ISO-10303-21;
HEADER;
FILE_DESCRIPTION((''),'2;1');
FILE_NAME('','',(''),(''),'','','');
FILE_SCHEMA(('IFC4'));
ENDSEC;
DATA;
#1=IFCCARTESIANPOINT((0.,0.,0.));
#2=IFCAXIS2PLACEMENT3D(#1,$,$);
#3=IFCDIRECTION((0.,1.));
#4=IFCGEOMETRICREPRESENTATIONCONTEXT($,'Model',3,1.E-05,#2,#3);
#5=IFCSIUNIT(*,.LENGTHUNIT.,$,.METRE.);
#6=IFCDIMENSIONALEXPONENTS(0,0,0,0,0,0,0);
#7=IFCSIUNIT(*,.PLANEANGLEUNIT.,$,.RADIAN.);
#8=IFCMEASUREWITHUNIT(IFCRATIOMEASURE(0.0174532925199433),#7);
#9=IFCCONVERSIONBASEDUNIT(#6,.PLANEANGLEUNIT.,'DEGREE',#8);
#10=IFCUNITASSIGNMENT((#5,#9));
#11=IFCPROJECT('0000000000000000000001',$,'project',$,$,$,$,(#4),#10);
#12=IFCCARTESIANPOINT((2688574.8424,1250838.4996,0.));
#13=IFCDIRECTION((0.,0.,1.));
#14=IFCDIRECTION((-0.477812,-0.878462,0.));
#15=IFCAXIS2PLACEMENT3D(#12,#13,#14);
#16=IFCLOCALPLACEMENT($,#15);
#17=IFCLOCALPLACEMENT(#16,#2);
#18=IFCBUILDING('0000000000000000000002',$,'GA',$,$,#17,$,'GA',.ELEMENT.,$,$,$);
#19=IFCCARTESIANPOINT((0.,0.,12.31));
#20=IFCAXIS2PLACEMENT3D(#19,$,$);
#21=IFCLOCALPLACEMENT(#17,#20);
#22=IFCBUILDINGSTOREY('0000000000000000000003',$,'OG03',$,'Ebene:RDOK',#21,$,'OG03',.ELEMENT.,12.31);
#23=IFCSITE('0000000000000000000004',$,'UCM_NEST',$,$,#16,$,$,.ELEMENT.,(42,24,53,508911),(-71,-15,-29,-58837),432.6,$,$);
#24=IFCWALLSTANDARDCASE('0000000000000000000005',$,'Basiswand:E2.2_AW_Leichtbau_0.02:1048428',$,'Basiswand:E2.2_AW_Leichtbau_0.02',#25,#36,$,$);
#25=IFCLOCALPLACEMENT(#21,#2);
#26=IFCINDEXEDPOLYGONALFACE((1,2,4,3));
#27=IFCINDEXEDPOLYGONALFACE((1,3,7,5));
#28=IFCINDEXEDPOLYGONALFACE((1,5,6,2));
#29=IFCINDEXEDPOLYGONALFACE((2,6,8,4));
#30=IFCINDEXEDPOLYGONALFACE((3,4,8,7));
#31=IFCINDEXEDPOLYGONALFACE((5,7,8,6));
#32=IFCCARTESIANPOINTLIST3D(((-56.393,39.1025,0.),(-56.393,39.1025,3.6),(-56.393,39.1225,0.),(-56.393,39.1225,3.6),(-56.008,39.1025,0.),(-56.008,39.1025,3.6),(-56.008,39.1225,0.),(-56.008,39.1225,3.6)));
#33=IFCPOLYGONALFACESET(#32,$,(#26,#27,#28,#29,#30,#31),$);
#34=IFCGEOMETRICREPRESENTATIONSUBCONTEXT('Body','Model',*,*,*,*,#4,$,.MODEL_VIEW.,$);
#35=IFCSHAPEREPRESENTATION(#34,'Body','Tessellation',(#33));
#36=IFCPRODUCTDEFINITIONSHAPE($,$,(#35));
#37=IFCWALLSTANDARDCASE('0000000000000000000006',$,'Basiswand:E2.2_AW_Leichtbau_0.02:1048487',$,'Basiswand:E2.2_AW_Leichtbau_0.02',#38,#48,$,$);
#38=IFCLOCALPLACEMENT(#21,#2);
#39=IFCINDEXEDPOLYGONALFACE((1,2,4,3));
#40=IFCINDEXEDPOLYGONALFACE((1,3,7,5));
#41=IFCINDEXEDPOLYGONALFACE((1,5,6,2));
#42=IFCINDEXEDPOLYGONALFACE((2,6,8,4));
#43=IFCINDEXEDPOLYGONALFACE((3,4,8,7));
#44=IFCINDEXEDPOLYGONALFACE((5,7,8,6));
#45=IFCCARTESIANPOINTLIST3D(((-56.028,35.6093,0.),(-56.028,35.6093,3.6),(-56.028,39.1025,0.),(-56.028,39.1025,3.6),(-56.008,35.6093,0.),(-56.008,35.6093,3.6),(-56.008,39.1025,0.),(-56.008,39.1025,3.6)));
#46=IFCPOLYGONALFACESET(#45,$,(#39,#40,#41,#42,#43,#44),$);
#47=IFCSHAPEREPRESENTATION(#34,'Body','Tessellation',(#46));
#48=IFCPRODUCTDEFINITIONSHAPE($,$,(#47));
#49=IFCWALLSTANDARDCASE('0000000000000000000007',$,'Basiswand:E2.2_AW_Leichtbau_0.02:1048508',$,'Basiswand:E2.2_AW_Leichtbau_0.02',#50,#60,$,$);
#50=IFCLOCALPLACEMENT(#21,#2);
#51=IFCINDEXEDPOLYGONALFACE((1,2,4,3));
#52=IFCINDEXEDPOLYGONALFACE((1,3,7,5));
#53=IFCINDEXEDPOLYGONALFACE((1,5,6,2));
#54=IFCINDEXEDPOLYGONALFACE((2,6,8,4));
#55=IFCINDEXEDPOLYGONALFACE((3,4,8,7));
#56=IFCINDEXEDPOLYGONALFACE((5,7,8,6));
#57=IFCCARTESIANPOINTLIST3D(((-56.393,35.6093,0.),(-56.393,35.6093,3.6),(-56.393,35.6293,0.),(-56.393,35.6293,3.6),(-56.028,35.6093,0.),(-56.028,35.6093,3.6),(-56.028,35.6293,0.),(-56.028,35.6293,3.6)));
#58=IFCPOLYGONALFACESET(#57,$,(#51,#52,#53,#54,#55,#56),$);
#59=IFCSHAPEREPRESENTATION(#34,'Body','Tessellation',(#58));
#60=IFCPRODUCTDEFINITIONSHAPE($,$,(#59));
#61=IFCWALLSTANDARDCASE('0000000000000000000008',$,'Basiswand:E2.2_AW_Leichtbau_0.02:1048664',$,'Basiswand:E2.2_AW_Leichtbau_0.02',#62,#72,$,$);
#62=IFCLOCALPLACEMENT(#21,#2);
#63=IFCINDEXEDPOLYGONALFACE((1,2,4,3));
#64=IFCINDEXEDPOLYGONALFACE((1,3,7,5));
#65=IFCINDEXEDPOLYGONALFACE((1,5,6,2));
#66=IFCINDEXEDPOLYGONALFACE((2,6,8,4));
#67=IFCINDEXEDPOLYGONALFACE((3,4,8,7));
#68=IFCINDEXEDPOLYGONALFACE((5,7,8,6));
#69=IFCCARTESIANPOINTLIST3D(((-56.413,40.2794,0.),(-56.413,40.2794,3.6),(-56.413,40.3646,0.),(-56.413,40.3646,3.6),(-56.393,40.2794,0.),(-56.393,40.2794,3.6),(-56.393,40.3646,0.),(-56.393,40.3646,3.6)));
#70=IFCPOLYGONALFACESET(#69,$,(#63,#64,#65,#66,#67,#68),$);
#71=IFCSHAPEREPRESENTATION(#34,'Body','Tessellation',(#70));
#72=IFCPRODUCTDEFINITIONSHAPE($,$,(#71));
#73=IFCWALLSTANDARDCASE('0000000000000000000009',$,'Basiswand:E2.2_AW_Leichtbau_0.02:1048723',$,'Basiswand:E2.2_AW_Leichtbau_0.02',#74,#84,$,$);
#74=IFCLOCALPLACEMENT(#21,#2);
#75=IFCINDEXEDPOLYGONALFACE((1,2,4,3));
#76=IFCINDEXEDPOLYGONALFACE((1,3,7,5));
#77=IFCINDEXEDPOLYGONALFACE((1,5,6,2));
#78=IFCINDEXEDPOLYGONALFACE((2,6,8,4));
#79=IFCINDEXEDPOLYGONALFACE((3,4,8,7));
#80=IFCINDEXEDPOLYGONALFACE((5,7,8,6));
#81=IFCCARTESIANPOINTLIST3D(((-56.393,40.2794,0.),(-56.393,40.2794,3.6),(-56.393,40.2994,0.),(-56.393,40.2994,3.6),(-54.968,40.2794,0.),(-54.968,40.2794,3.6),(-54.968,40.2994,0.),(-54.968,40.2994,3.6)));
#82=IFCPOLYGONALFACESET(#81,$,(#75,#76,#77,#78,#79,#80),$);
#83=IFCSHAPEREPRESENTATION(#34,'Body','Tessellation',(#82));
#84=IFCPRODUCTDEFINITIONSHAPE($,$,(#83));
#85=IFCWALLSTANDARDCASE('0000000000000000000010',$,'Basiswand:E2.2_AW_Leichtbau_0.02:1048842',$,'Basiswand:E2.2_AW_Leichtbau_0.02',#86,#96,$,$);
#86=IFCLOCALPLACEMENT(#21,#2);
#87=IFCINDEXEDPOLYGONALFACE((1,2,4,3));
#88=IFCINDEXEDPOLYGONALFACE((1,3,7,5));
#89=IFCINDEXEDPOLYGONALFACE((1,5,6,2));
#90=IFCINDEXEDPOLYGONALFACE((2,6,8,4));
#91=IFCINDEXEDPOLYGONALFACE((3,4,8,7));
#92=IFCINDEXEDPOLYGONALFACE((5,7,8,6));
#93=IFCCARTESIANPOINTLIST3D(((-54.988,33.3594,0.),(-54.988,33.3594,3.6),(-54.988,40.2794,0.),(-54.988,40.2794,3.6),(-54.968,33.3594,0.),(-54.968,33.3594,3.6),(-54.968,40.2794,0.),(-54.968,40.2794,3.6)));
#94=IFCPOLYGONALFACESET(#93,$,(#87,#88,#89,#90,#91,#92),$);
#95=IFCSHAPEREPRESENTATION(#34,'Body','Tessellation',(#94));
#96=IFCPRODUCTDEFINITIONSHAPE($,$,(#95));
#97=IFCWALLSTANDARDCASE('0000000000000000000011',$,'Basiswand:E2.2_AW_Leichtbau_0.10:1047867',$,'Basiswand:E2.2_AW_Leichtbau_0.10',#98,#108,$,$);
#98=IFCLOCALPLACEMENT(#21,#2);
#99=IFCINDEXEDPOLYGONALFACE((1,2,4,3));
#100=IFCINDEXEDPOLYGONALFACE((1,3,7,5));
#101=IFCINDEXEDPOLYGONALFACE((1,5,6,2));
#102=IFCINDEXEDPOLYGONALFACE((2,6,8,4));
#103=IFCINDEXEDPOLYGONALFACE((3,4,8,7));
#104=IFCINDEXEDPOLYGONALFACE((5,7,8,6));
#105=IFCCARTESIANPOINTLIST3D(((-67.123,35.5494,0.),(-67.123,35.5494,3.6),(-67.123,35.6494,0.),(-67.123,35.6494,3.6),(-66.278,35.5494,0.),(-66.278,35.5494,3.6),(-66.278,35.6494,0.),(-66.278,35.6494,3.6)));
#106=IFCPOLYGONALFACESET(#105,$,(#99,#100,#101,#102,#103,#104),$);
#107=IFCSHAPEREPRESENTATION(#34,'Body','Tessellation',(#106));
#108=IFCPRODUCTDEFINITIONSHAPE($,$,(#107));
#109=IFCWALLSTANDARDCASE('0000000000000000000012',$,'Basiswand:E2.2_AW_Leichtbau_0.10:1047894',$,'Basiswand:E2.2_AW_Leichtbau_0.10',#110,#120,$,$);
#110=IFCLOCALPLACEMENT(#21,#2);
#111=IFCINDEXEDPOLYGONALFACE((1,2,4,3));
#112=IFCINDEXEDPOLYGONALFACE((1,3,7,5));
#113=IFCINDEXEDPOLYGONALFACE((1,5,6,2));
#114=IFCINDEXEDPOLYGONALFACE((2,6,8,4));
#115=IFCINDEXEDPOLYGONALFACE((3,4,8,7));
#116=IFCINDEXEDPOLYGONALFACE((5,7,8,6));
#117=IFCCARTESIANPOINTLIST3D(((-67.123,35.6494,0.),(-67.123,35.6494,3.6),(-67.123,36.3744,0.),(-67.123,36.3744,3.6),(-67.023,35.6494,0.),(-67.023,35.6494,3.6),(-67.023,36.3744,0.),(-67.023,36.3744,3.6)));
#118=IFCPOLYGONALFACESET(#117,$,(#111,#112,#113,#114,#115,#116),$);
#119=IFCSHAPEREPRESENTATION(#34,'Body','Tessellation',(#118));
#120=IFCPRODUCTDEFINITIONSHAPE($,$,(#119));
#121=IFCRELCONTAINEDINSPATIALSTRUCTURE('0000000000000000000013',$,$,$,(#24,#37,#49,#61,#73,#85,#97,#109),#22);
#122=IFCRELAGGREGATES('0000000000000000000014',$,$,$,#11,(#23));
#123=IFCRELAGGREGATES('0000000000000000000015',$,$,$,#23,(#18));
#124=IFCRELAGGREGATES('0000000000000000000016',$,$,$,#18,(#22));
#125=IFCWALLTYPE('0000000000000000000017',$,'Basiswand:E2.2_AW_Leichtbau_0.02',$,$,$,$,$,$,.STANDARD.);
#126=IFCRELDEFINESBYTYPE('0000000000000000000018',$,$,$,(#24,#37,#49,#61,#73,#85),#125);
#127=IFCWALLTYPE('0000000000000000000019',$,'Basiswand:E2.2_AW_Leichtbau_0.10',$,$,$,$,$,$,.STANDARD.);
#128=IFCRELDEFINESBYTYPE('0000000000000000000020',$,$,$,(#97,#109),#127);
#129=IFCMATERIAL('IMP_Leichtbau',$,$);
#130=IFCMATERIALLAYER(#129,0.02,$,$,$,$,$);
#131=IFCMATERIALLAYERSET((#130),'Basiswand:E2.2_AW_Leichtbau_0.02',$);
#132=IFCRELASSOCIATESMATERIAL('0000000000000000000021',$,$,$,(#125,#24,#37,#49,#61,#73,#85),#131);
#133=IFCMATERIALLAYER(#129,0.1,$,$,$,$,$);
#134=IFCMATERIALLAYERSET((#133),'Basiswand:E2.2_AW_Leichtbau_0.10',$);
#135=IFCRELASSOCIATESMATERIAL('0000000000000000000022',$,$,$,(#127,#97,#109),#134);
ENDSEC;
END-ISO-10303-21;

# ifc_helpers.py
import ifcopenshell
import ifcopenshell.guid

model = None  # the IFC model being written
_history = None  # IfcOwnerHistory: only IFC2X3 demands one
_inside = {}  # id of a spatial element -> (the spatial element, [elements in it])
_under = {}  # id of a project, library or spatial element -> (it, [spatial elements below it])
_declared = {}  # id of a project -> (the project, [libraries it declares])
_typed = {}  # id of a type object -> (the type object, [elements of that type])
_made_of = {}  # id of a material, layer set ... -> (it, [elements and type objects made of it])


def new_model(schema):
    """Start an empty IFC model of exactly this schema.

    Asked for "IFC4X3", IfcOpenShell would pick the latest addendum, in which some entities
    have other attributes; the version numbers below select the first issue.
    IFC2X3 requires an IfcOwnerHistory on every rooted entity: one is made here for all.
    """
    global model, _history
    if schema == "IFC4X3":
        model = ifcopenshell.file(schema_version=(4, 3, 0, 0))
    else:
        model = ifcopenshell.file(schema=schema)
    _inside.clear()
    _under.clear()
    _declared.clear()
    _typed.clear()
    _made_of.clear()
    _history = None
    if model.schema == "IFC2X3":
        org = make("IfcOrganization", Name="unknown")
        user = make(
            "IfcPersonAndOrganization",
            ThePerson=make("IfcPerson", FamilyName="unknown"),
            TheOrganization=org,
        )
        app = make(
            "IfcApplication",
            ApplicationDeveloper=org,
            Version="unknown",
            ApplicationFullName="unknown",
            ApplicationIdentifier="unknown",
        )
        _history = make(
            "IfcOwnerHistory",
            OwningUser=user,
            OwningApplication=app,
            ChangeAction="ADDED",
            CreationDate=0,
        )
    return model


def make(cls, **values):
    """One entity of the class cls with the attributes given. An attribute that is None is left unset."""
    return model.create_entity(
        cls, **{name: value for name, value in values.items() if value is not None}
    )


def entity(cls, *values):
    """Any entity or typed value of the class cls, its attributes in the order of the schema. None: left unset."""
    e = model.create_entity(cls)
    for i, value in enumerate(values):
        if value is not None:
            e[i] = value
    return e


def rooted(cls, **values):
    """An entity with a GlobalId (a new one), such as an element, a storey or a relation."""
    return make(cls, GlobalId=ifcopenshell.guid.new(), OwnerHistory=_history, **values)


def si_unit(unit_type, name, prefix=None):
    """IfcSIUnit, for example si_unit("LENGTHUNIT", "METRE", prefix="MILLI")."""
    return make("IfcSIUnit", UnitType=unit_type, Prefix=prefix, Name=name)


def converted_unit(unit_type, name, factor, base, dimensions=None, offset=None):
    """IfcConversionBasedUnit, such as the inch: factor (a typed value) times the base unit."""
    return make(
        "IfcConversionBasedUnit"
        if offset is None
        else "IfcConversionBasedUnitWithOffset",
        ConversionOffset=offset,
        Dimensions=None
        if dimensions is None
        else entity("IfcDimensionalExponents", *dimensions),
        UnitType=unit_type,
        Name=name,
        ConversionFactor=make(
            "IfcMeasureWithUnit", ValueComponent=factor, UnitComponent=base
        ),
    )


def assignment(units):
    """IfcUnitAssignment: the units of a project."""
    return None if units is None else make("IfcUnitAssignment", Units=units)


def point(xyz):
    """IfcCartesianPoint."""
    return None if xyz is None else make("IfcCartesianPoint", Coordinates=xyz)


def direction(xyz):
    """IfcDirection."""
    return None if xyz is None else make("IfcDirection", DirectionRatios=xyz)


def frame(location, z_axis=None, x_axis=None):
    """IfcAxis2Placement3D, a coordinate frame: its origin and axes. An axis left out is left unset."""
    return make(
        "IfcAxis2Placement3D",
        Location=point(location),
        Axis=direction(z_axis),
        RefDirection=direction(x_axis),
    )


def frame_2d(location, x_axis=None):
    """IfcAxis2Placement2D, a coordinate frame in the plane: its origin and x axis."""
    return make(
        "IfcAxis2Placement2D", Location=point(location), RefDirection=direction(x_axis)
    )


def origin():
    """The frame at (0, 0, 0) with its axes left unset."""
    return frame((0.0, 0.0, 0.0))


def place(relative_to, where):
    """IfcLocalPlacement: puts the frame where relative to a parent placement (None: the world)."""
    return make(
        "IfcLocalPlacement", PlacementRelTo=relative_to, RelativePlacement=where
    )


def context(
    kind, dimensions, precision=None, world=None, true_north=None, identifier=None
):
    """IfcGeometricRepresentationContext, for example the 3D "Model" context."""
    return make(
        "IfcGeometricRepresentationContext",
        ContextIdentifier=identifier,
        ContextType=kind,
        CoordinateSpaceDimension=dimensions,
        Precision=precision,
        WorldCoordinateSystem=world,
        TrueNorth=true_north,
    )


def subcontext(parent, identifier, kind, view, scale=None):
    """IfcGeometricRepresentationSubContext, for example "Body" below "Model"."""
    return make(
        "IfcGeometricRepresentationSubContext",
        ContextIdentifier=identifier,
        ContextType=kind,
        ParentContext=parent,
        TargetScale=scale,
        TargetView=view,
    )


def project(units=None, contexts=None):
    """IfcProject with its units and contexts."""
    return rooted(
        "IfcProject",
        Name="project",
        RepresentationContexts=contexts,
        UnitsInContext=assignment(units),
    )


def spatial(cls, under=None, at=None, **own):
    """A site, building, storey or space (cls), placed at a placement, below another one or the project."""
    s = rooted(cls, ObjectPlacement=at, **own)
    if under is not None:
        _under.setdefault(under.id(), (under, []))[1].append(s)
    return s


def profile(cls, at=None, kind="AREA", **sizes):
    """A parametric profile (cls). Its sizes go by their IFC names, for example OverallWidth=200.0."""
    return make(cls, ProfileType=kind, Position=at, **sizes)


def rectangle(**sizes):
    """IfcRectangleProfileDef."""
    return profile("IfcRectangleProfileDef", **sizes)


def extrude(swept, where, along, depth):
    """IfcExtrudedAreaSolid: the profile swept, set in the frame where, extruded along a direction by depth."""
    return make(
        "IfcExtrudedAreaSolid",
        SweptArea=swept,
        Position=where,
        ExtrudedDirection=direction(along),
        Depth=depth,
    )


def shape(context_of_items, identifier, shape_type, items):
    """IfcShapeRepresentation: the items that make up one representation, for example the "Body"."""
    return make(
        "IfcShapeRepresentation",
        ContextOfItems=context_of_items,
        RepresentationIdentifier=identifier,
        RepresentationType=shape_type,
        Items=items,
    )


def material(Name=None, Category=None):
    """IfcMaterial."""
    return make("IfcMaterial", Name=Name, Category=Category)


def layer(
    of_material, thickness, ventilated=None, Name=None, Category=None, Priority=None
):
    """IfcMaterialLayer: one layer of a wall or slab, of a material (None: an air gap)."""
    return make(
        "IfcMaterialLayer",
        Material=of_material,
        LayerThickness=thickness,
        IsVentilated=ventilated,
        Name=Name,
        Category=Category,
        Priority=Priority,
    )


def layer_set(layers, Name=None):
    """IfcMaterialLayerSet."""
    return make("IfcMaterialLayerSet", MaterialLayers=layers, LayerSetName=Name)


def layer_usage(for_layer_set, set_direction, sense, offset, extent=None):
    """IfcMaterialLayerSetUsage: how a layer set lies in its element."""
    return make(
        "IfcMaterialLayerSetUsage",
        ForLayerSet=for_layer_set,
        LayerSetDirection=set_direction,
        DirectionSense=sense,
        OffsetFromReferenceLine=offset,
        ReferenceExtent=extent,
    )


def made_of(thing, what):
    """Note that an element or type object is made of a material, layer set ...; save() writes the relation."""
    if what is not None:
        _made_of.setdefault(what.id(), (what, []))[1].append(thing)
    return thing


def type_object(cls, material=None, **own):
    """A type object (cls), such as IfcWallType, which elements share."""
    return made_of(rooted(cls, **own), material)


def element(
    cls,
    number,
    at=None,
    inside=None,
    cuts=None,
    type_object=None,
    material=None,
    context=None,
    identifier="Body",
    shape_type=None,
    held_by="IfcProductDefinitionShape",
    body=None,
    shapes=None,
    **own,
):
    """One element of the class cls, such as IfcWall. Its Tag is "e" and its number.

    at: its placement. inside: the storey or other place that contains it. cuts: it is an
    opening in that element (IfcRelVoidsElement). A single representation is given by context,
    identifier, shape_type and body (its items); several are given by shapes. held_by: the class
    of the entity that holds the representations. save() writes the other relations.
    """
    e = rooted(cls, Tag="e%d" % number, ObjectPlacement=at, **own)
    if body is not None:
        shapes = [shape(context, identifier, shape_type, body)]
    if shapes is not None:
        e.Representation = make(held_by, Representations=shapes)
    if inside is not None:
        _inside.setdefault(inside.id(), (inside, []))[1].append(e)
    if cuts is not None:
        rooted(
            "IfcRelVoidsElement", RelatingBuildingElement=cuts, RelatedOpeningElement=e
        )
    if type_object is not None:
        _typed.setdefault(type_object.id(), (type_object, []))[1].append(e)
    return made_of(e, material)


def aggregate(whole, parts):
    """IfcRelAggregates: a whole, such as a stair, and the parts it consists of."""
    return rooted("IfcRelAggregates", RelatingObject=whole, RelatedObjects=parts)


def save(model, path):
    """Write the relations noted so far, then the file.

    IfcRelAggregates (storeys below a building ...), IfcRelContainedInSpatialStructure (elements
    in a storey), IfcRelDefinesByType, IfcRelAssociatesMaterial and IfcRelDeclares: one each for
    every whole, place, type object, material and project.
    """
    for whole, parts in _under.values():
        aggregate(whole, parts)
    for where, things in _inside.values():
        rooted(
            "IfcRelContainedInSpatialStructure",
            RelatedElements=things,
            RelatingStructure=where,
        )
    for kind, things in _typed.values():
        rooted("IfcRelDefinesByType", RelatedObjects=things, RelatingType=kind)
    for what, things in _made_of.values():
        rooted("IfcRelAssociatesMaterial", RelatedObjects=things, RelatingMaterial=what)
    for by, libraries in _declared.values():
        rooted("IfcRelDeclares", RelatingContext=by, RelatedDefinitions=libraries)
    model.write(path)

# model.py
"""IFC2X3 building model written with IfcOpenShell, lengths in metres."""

from ifc_helpers import new_model, entity, si_unit, converted_unit, direction, frame, frame_2d, origin, place, context, subcontext, project, spatial, rectangle, extrude, material, layer, layer_set, layer_usage, type_object, element, save


model = new_model("IFC2X3")

# Units and contexts
model_context = context("Model", 3, precision=1e-05, world=origin(), true_north=direction((0.0, 1.0)))
body_context = subcontext(model_context, "Body", "Model", "MODEL_VIEW")
ifc_project = project(units=[si_unit("LENGTHUNIT", "METRE"), converted_unit("PLANEANGLEUNIT", "DEGREE", entity("IfcRatioMeasure", 0.0174532925199433), si_unit("PLANEANGLEUNIT", "RADIAN"), dimensions=[0, 0, 0, 0, 0, 0, 0])], contexts=[model_context])

# Site, building, storey
site_placement = place(None, frame((2688574.8424, 1250838.4996, 0.0), z_axis=(0.0, 0.0, 1.0), x_axis=(-0.477812, -0.878462, 0.0)))
site = spatial("IfcSite", under=ifc_project, at=site_placement, Name="UCM_NEST", CompositionType="ELEMENT", RefLatitude=(42, 24, 53, 508911), RefLongitude=(-71, -15, -29, -58837), RefElevation=432.6)
building_placement = place(site_placement, origin())
building = spatial("IfcBuilding", under=site, at=building_placement, Name="GA", LongName="GA", CompositionType="ELEMENT")
storey_placement = place(building_placement, frame((0.0, 0.0, 12.31)))
storey = spatial("IfcBuildingStorey", under=building, at=storey_placement, Name="OG03", ObjectType="Ebene:RDOK", LongName="OG03", CompositionType="ELEMENT", Elevation=12.31)

# Walls
ifc_material_1 = material(Name="IMP_Leichtbau")
ifc_layer_1 = layer(ifc_material_1, 0.02)
ifc_layer_set_1 = layer_set([ifc_layer_1], Name="Basiswand:E2.2_AW_Leichtbau_0.02")
wall_type_1 = type_object("IfcWallType", Name="Basiswand:E2.2_AW_Leichtbau_0.02", PredefinedType="STANDARD", material=ifc_layer_set_1)
ifc_layer_usage_1 = layer_usage(ifc_layer_set_1, "AXIS2", "NEGATIVE", 0.01)
wall_1_placement = place(storey_placement, frame((-56.393, 39.1125, 0.0)))
element("IfcWallStandardCase", 1, at=wall_1_placement, inside=storey, type_object=wall_type_1, material=ifc_layer_usage_1, Name="Basiswand:E2.2_AW_Leichtbau_0.02:1048428", ObjectType="Basiswand:E2.2_AW_Leichtbau_0.02", context=body_context, shape_type="SweptSolid", body=[
    extrude(rectangle(XDim=0.385, YDim=0.02, at=frame_2d((0.1925, 0.0), x_axis=(-1.0, 0.0))), origin(), (0.0, 0.0, 1.0), 3.6),
])
ifc_layer_usage_2 = layer_usage(ifc_layer_set_1, "AXIS2", "NEGATIVE", 0.01)
wall_2_placement = place(storey_placement, frame((-56.018, 39.1025, 0.0), z_axis=(0.0, 0.0, 1.0), x_axis=(0.0, -1.0, 0.0)))
element("IfcWallStandardCase", 2, at=wall_2_placement, inside=storey, type_object=wall_type_1, material=ifc_layer_usage_2, Name="Basiswand:E2.2_AW_Leichtbau_0.02:1048487", ObjectType="Basiswand:E2.2_AW_Leichtbau_0.02", context=body_context, shape_type="SweptSolid", body=[
    extrude(rectangle(XDim=3.4932, YDim=0.02, at=frame_2d((1.7466, 0.0), x_axis=(-1.0, 0.0))), origin(), (0.0, 0.0, 1.0), 3.6),
])
ifc_layer_usage_3 = layer_usage(ifc_layer_set_1, "AXIS2", "NEGATIVE", 0.01)
wall_3_placement = place(storey_placement, frame((-56.028, 35.6193, 0.0), z_axis=(0.0, 0.0, 1.0), x_axis=(-1.0, 0.0, 0.0)))
element("IfcWallStandardCase", 3, at=wall_3_placement, inside=storey, type_object=wall_type_1, material=ifc_layer_usage_3, Name="Basiswand:E2.2_AW_Leichtbau_0.02:1048508", ObjectType="Basiswand:E2.2_AW_Leichtbau_0.02", context=body_context, shape_type="SweptSolid", body=[
    extrude(rectangle(XDim=0.365, YDim=0.02, at=frame_2d((0.1825, 0.0), x_axis=(-1.0, 0.0))), origin(), (0.0, 0.0, 1.0), 3.6),
])
ifc_layer_usage_4 = layer_usage(ifc_layer_set_1, "AXIS2", "NEGATIVE", 0.01)
wall_4_placement = place(storey_placement, frame((-56.403, 40.3646, 0.0), z_axis=(0.0, 0.0, 1.0), x_axis=(0.0, -1.0, 0.0)))
element("IfcWallStandardCase", 4, at=wall_4_placement, inside=storey, type_object=wall_type_1, material=ifc_layer_usage_4, Name="Basiswand:E2.2_AW_Leichtbau_0.02:1048664", ObjectType="Basiswand:E2.2_AW_Leichtbau_0.02", context=body_context, shape_type="SweptSolid", body=[
    extrude(rectangle(XDim=0.0852, YDim=0.02, at=frame_2d((0.0426, 0.0), x_axis=(-1.0, 0.0))), origin(), (0.0, 0.0, 1.0), 3.6),
])
ifc_layer_usage_5 = layer_usage(ifc_layer_set_1, "AXIS2", "NEGATIVE", 0.01)
wall_5_placement = place(storey_placement, frame((-56.393, 40.2894, 0.0)))
element("IfcWallStandardCase", 5, at=wall_5_placement, inside=storey, type_object=wall_type_1, material=ifc_layer_usage_5, Name="Basiswand:E2.2_AW_Leichtbau_0.02:1048723", ObjectType="Basiswand:E2.2_AW_Leichtbau_0.02", context=body_context, shape_type="SweptSolid", body=[
    extrude(rectangle(XDim=1.425, YDim=0.02, at=frame_2d((0.7125, 0.0), x_axis=(-1.0, 0.0))), origin(), (0.0, 0.0, 1.0), 3.6),
])
ifc_layer_usage_6 = layer_usage(ifc_layer_set_1, "AXIS2", "NEGATIVE", 0.01)
wall_6_placement = place(storey_placement, frame((-54.978, 40.2794, 0.0), z_axis=(0.0, 0.0, 1.0), x_axis=(0.0, -1.0, 0.0)))
element("IfcWallStandardCase", 6, at=wall_6_placement, inside=storey, type_object=wall_type_1, material=ifc_layer_usage_6, Name="Basiswand:E2.2_AW_Leichtbau_0.02:1048842", ObjectType="Basiswand:E2.2_AW_Leichtbau_0.02", context=body_context, shape_type="SweptSolid", body=[
    extrude(rectangle(XDim=6.92, YDim=0.02, at=frame_2d((3.46, 0.0), x_axis=(-1.0, 0.0))), origin(), (0.0, 0.0, 1.0), 3.6),
])
ifc_layer_2 = layer(ifc_material_1, 0.1)
ifc_layer_set_2 = layer_set([ifc_layer_2], Name="Basiswand:E2.2_AW_Leichtbau_0.10")
ifc_layer_usage_7 = layer_usage(ifc_layer_set_2, "AXIS2", "NEGATIVE", 0.05)
wall_type_2 = type_object("IfcWallType", Name="Basiswand:E2.2_AW_Leichtbau_0.10", PredefinedType="STANDARD", material=ifc_layer_set_2)
wall_7_placement = place(storey_placement, frame((-66.278, 35.5994, 0.0), z_axis=(0.0, 0.0, 1.0), x_axis=(-1.0, 0.0, 0.0)))
element("IfcWallStandardCase", 7, at=wall_7_placement, inside=storey, type_object=wall_type_2, material=ifc_layer_usage_7, Name="Basiswand:E2.2_AW_Leichtbau_0.10:1047867", ObjectType="Basiswand:E2.2_AW_Leichtbau_0.10", context=body_context, shape_type="SweptSolid", body=[
    extrude(rectangle(XDim=0.845, YDim=0.1, at=frame_2d((0.4225, 0.0), x_axis=(-1.0, 0.0))), origin(), (0.0, 0.0, 1.0), 3.6),
])
ifc_layer_usage_8 = layer_usage(ifc_layer_set_2, "AXIS2", "NEGATIVE", 0.05)
wall_8_placement = place(storey_placement, frame((-67.073, 35.6494, 0.0), z_axis=(0.0, 0.0, 1.0), x_axis=(0.0, 1.0, 0.0)))
element("IfcWallStandardCase", 8, at=wall_8_placement, inside=storey, type_object=wall_type_2, material=ifc_layer_usage_8, Name="Basiswand:E2.2_AW_Leichtbau_0.10:1047894", ObjectType="Basiswand:E2.2_AW_Leichtbau_0.10", context=body_context, shape_type="SweptSolid", body=[
    extrude(rectangle(XDim=0.725, YDim=0.1, at=frame_2d((0.3625, 0.0), x_axis=(-1.0, 0.0))), origin(), (0.0, 0.0, 1.0), 3.6),
])

save(model, "model.ifc")
